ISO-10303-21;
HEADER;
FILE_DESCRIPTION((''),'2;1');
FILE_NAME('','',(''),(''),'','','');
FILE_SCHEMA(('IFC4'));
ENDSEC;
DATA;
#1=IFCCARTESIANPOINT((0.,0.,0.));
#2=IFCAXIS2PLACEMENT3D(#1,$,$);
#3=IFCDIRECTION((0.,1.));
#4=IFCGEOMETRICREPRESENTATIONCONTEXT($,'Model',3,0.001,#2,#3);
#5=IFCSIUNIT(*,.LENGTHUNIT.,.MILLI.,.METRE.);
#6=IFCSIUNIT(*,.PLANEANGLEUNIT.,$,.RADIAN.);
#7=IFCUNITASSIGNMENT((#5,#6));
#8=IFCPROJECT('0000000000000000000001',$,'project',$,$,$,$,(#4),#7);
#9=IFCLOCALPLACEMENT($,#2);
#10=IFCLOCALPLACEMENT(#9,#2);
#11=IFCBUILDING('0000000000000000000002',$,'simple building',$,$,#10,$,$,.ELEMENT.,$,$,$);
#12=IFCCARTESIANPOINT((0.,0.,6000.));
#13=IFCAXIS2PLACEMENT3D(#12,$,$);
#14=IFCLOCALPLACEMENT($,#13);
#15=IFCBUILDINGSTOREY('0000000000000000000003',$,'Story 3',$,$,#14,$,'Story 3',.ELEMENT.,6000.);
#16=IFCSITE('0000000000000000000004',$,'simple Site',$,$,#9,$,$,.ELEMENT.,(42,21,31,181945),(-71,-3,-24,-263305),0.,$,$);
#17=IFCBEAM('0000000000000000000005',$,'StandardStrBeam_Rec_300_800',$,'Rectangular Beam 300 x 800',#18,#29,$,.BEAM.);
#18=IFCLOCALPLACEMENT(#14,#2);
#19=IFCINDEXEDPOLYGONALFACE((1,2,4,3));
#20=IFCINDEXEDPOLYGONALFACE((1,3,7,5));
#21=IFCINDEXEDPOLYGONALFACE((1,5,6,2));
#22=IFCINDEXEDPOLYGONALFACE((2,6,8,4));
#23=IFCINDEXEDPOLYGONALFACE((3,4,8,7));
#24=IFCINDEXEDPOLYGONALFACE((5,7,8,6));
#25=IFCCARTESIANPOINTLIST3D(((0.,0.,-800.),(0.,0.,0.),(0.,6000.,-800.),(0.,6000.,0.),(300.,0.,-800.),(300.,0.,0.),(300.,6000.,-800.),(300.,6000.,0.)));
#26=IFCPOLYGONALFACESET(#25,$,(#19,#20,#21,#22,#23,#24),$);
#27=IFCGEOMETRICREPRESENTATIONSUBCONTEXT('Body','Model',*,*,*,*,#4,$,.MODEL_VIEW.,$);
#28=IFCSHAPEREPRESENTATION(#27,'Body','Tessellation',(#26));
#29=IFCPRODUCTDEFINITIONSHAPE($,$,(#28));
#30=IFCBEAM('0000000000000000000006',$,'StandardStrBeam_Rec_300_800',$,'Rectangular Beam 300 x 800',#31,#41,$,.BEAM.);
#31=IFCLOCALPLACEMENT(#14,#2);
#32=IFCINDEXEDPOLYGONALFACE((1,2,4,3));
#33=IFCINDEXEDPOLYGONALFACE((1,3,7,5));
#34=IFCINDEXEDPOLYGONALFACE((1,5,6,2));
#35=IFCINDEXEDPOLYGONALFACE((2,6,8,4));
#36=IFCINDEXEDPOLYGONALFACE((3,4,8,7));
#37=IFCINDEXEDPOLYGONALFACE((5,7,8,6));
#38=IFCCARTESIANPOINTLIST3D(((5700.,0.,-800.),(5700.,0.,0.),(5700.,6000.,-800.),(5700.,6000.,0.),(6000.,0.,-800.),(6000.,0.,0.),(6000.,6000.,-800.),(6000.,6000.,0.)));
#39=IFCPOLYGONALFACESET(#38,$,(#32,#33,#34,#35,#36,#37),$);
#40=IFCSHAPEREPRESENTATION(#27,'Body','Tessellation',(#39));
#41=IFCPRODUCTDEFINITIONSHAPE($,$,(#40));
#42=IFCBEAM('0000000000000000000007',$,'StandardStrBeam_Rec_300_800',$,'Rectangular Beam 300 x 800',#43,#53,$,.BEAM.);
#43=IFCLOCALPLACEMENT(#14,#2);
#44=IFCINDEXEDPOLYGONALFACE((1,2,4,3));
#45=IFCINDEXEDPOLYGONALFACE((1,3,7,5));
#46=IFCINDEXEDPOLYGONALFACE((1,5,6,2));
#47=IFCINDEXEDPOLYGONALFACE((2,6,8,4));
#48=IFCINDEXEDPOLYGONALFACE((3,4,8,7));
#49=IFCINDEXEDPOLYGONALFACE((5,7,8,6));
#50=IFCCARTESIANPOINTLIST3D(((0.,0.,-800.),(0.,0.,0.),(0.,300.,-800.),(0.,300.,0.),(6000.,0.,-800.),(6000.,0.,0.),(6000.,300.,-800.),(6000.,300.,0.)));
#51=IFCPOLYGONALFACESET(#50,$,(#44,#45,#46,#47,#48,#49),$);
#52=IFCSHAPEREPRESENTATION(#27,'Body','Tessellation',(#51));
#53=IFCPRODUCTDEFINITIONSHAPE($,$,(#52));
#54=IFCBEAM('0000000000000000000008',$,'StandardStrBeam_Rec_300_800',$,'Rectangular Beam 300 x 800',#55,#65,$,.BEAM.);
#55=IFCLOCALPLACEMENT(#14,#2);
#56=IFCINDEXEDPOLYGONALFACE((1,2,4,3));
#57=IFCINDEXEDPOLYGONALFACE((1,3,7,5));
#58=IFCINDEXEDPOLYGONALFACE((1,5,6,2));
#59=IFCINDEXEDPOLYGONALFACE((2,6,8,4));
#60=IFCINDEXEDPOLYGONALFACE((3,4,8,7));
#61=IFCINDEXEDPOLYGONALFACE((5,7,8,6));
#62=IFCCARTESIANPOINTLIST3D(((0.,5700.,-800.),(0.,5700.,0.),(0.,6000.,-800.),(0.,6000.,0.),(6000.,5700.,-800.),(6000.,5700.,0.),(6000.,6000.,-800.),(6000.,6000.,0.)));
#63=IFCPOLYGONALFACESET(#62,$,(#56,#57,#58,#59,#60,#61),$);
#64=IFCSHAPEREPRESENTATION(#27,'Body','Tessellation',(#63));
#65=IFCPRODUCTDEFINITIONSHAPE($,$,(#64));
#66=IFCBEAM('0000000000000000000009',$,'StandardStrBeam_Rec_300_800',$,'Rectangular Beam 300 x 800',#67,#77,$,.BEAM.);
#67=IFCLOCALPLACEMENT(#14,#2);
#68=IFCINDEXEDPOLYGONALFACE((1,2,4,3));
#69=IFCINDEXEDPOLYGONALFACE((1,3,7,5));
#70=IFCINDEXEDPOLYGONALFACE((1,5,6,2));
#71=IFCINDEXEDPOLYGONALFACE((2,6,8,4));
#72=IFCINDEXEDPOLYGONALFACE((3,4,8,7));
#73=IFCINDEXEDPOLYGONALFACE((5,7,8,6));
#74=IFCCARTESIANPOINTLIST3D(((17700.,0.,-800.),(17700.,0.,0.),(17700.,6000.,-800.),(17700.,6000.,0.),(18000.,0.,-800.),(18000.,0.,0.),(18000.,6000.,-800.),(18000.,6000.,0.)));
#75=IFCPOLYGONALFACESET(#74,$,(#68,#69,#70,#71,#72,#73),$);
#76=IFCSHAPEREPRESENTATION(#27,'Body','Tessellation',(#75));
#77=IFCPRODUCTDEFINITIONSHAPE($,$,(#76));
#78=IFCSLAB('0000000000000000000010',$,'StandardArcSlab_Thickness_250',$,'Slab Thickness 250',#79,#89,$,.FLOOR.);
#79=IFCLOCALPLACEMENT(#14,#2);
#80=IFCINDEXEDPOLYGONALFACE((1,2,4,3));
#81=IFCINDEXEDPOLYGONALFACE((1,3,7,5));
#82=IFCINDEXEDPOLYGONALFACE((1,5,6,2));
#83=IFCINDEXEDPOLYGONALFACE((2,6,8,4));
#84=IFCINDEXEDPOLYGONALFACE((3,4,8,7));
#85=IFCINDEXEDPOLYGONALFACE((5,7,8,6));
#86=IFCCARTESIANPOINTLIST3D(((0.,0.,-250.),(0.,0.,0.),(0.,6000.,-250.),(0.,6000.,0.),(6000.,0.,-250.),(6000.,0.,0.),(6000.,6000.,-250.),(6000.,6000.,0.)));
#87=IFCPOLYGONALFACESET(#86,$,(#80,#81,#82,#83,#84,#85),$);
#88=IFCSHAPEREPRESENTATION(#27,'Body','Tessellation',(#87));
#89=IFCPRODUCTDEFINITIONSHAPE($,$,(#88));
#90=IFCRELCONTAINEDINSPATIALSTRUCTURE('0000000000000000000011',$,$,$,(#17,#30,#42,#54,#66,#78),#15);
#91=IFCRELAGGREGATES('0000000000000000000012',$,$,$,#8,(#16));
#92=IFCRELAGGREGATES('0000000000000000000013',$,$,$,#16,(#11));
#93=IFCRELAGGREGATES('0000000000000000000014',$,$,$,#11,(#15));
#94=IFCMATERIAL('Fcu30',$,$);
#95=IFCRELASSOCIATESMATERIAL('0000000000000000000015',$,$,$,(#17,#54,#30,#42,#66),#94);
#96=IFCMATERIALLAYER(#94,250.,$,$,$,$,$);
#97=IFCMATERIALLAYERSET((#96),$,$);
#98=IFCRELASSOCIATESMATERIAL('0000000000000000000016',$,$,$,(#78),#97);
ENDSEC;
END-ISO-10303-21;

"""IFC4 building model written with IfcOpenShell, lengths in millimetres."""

from ifc_helpers import new_model, si_unit, direction, frame, origin, origin_with_axes, origin_2d_with_axis, place, context, subcontext, project, spatial, polyline, rectangle, outline, extrude, material, layer, layer_set, layer_usage, material_profile, profile_set, profile_usage, element, save


model = new_model("IFC4")

# Units and contexts
model_context = context("Model", 3, precision=0.001, world=origin(), true_north=direction((0.0, 1.0)))
body_context = subcontext(model_context, "Body", "Model", "MODEL_VIEW")
ifc_project = project(units=[si_unit("LENGTHUNIT", "METRE", prefix="MILLI"), si_unit("PLANEANGLEUNIT", "RADIAN")], contexts=[model_context])

# Site, building, storey
site_placement = place(None, origin())
site = spatial("IfcSite", under=ifc_project, at=site_placement, Name="simple Site", CompositionType="ELEMENT", RefLatitude=(42, 21, 31, 181945), RefLongitude=(-71, -3, -24, -263305), RefElevation=0.0)
building_placement = place(site_placement, origin())
building = spatial("IfcBuilding", under=site, at=building_placement, Name="simple building", CompositionType="ELEMENT")
storey_placement = place(None, frame((0.0, 0.0, 6000.0)))
storey = spatial("IfcBuildingStorey", under=building, at=storey_placement, Name="Story 3", LongName="Story 3", CompositionType="ELEMENT", Elevation=6000.0)

# Beams
ifc_material = material(Name="Fcu30")
ifc_material_profile = material_profile(ifc_material, rectangle(XDim=300.0, YDim=800.0, at=origin_2d_with_axis()))
ifc_profile_set = profile_set([ifc_material_profile])
ifc_profile_usage_1 = profile_usage(ifc_profile_set, cardinal=7)
beam_1_placement = place(None, frame((150.0, 0.0, 5600.0), z_axis=(0.0, 1.0, 0.0), x_axis=(1.0, 0.0, 0.0)))
element("IfcBeam", 1, at=beam_1_placement, inside=storey, material=ifc_profile_usage_1, Name="StandardStrBeam_Rec_300_800", ObjectType="Rectangular Beam 300 x 800", PredefinedType="BEAM", context=body_context, shape_type="SweptSolid", body=[
    extrude(rectangle(XDim=300.0, YDim=800.0, at=origin_2d_with_axis()), origin_with_axes(), (0.0, 0.0, 1.0), 6000.0),
])
ifc_profile_usage_2 = profile_usage(ifc_profile_set, cardinal=9)
for number, where, z_axis, x_axis, name in (
    (2, (5850.0, 0.0, 5600.0), (0.0, 1.0, 0.0), (1.0, 0.0, 0.0), "StandardStrBeam_Rec_300_800"),
    (3, (0.0, 150.0, 5600.0), (1.0, 0.0, 0.0), (0.0, -1.0, 0.0), "StandardStrBeam_Rec_300_800"),
):
    element("IfcBeam", number, at=place(None, frame(where, z_axis=z_axis, x_axis=x_axis)), inside=storey, material=ifc_profile_usage_2, Name=name, ObjectType="Rectangular Beam 300 x 800", PredefinedType="BEAM", context=body_context, shape_type="SweptSolid", body=[
        extrude(rectangle(XDim=300.0, YDim=800.0, at=origin_2d_with_axis()), origin_with_axes(), (0.0, 0.0, 1.0), 6000.0),
    ])
beam_2_placement = place(None, frame((0.0, 5850.0, 5600.0), z_axis=(1.0, 0.0, 0.0), x_axis=(0.0, -1.0, 0.0)))
element("IfcBeam", 4, at=beam_2_placement, inside=storey, material=ifc_profile_usage_1, Name="StandardStrBeam_Rec_300_800", ObjectType="Rectangular Beam 300 x 800", PredefinedType="BEAM", context=body_context, shape_type="SweptSolid", body=[
    extrude(rectangle(XDim=300.0, YDim=800.0, at=origin_2d_with_axis()), origin_with_axes(), (0.0, 0.0, 1.0), 6000.0),
])
beam_3_placement = place(None, frame((17850.0, 0.0, 5600.0), z_axis=(0.0, 1.0, 0.0), x_axis=(1.0, 0.0, 0.0)))
element("IfcBeam", 5, at=beam_3_placement, inside=storey, material=ifc_profile_usage_2, Name="StandardStrBeam_Rec_300_800", ObjectType="Rectangular Beam 300 x 800", PredefinedType="BEAM", context=body_context, shape_type="SweptSolid", body=[
    extrude(rectangle(XDim=300.0, YDim=800.0, at=origin_2d_with_axis()), origin_with_axes(), (0.0, 0.0, 1.0), 6000.0),
])

# Slab
ifc_layer = layer(ifc_material, 250.0)
ifc_layer_set = layer_set([ifc_layer])
ifc_layer_usage = layer_usage(ifc_layer_set, "AXIS3", "POSITIVE", -250.0)
slab_placement = place(None, frame((0.0, 0.0, 5750.0), z_axis=(0.0, 0.0, 1.0), x_axis=(1.0, 0.0, 0.0)))
element("IfcSlab", 6, at=slab_placement, inside=storey, material=ifc_layer_usage, Name="StandardArcSlab_Thickness_250", ObjectType="Slab Thickness 250", PredefinedType="FLOOR", context=body_context, shape_type="SweptSolid", body=[
    extrude(outline(polyline([(0.0, 0.0), (6000.0, 0.0), (6000.0, 6000.0), (0.0, 6000.0), (0.0, 0.0)])), origin_with_axes(), (0.0, 0.0, 1.0), 250.0),
])

save(model, "model.ifc")
